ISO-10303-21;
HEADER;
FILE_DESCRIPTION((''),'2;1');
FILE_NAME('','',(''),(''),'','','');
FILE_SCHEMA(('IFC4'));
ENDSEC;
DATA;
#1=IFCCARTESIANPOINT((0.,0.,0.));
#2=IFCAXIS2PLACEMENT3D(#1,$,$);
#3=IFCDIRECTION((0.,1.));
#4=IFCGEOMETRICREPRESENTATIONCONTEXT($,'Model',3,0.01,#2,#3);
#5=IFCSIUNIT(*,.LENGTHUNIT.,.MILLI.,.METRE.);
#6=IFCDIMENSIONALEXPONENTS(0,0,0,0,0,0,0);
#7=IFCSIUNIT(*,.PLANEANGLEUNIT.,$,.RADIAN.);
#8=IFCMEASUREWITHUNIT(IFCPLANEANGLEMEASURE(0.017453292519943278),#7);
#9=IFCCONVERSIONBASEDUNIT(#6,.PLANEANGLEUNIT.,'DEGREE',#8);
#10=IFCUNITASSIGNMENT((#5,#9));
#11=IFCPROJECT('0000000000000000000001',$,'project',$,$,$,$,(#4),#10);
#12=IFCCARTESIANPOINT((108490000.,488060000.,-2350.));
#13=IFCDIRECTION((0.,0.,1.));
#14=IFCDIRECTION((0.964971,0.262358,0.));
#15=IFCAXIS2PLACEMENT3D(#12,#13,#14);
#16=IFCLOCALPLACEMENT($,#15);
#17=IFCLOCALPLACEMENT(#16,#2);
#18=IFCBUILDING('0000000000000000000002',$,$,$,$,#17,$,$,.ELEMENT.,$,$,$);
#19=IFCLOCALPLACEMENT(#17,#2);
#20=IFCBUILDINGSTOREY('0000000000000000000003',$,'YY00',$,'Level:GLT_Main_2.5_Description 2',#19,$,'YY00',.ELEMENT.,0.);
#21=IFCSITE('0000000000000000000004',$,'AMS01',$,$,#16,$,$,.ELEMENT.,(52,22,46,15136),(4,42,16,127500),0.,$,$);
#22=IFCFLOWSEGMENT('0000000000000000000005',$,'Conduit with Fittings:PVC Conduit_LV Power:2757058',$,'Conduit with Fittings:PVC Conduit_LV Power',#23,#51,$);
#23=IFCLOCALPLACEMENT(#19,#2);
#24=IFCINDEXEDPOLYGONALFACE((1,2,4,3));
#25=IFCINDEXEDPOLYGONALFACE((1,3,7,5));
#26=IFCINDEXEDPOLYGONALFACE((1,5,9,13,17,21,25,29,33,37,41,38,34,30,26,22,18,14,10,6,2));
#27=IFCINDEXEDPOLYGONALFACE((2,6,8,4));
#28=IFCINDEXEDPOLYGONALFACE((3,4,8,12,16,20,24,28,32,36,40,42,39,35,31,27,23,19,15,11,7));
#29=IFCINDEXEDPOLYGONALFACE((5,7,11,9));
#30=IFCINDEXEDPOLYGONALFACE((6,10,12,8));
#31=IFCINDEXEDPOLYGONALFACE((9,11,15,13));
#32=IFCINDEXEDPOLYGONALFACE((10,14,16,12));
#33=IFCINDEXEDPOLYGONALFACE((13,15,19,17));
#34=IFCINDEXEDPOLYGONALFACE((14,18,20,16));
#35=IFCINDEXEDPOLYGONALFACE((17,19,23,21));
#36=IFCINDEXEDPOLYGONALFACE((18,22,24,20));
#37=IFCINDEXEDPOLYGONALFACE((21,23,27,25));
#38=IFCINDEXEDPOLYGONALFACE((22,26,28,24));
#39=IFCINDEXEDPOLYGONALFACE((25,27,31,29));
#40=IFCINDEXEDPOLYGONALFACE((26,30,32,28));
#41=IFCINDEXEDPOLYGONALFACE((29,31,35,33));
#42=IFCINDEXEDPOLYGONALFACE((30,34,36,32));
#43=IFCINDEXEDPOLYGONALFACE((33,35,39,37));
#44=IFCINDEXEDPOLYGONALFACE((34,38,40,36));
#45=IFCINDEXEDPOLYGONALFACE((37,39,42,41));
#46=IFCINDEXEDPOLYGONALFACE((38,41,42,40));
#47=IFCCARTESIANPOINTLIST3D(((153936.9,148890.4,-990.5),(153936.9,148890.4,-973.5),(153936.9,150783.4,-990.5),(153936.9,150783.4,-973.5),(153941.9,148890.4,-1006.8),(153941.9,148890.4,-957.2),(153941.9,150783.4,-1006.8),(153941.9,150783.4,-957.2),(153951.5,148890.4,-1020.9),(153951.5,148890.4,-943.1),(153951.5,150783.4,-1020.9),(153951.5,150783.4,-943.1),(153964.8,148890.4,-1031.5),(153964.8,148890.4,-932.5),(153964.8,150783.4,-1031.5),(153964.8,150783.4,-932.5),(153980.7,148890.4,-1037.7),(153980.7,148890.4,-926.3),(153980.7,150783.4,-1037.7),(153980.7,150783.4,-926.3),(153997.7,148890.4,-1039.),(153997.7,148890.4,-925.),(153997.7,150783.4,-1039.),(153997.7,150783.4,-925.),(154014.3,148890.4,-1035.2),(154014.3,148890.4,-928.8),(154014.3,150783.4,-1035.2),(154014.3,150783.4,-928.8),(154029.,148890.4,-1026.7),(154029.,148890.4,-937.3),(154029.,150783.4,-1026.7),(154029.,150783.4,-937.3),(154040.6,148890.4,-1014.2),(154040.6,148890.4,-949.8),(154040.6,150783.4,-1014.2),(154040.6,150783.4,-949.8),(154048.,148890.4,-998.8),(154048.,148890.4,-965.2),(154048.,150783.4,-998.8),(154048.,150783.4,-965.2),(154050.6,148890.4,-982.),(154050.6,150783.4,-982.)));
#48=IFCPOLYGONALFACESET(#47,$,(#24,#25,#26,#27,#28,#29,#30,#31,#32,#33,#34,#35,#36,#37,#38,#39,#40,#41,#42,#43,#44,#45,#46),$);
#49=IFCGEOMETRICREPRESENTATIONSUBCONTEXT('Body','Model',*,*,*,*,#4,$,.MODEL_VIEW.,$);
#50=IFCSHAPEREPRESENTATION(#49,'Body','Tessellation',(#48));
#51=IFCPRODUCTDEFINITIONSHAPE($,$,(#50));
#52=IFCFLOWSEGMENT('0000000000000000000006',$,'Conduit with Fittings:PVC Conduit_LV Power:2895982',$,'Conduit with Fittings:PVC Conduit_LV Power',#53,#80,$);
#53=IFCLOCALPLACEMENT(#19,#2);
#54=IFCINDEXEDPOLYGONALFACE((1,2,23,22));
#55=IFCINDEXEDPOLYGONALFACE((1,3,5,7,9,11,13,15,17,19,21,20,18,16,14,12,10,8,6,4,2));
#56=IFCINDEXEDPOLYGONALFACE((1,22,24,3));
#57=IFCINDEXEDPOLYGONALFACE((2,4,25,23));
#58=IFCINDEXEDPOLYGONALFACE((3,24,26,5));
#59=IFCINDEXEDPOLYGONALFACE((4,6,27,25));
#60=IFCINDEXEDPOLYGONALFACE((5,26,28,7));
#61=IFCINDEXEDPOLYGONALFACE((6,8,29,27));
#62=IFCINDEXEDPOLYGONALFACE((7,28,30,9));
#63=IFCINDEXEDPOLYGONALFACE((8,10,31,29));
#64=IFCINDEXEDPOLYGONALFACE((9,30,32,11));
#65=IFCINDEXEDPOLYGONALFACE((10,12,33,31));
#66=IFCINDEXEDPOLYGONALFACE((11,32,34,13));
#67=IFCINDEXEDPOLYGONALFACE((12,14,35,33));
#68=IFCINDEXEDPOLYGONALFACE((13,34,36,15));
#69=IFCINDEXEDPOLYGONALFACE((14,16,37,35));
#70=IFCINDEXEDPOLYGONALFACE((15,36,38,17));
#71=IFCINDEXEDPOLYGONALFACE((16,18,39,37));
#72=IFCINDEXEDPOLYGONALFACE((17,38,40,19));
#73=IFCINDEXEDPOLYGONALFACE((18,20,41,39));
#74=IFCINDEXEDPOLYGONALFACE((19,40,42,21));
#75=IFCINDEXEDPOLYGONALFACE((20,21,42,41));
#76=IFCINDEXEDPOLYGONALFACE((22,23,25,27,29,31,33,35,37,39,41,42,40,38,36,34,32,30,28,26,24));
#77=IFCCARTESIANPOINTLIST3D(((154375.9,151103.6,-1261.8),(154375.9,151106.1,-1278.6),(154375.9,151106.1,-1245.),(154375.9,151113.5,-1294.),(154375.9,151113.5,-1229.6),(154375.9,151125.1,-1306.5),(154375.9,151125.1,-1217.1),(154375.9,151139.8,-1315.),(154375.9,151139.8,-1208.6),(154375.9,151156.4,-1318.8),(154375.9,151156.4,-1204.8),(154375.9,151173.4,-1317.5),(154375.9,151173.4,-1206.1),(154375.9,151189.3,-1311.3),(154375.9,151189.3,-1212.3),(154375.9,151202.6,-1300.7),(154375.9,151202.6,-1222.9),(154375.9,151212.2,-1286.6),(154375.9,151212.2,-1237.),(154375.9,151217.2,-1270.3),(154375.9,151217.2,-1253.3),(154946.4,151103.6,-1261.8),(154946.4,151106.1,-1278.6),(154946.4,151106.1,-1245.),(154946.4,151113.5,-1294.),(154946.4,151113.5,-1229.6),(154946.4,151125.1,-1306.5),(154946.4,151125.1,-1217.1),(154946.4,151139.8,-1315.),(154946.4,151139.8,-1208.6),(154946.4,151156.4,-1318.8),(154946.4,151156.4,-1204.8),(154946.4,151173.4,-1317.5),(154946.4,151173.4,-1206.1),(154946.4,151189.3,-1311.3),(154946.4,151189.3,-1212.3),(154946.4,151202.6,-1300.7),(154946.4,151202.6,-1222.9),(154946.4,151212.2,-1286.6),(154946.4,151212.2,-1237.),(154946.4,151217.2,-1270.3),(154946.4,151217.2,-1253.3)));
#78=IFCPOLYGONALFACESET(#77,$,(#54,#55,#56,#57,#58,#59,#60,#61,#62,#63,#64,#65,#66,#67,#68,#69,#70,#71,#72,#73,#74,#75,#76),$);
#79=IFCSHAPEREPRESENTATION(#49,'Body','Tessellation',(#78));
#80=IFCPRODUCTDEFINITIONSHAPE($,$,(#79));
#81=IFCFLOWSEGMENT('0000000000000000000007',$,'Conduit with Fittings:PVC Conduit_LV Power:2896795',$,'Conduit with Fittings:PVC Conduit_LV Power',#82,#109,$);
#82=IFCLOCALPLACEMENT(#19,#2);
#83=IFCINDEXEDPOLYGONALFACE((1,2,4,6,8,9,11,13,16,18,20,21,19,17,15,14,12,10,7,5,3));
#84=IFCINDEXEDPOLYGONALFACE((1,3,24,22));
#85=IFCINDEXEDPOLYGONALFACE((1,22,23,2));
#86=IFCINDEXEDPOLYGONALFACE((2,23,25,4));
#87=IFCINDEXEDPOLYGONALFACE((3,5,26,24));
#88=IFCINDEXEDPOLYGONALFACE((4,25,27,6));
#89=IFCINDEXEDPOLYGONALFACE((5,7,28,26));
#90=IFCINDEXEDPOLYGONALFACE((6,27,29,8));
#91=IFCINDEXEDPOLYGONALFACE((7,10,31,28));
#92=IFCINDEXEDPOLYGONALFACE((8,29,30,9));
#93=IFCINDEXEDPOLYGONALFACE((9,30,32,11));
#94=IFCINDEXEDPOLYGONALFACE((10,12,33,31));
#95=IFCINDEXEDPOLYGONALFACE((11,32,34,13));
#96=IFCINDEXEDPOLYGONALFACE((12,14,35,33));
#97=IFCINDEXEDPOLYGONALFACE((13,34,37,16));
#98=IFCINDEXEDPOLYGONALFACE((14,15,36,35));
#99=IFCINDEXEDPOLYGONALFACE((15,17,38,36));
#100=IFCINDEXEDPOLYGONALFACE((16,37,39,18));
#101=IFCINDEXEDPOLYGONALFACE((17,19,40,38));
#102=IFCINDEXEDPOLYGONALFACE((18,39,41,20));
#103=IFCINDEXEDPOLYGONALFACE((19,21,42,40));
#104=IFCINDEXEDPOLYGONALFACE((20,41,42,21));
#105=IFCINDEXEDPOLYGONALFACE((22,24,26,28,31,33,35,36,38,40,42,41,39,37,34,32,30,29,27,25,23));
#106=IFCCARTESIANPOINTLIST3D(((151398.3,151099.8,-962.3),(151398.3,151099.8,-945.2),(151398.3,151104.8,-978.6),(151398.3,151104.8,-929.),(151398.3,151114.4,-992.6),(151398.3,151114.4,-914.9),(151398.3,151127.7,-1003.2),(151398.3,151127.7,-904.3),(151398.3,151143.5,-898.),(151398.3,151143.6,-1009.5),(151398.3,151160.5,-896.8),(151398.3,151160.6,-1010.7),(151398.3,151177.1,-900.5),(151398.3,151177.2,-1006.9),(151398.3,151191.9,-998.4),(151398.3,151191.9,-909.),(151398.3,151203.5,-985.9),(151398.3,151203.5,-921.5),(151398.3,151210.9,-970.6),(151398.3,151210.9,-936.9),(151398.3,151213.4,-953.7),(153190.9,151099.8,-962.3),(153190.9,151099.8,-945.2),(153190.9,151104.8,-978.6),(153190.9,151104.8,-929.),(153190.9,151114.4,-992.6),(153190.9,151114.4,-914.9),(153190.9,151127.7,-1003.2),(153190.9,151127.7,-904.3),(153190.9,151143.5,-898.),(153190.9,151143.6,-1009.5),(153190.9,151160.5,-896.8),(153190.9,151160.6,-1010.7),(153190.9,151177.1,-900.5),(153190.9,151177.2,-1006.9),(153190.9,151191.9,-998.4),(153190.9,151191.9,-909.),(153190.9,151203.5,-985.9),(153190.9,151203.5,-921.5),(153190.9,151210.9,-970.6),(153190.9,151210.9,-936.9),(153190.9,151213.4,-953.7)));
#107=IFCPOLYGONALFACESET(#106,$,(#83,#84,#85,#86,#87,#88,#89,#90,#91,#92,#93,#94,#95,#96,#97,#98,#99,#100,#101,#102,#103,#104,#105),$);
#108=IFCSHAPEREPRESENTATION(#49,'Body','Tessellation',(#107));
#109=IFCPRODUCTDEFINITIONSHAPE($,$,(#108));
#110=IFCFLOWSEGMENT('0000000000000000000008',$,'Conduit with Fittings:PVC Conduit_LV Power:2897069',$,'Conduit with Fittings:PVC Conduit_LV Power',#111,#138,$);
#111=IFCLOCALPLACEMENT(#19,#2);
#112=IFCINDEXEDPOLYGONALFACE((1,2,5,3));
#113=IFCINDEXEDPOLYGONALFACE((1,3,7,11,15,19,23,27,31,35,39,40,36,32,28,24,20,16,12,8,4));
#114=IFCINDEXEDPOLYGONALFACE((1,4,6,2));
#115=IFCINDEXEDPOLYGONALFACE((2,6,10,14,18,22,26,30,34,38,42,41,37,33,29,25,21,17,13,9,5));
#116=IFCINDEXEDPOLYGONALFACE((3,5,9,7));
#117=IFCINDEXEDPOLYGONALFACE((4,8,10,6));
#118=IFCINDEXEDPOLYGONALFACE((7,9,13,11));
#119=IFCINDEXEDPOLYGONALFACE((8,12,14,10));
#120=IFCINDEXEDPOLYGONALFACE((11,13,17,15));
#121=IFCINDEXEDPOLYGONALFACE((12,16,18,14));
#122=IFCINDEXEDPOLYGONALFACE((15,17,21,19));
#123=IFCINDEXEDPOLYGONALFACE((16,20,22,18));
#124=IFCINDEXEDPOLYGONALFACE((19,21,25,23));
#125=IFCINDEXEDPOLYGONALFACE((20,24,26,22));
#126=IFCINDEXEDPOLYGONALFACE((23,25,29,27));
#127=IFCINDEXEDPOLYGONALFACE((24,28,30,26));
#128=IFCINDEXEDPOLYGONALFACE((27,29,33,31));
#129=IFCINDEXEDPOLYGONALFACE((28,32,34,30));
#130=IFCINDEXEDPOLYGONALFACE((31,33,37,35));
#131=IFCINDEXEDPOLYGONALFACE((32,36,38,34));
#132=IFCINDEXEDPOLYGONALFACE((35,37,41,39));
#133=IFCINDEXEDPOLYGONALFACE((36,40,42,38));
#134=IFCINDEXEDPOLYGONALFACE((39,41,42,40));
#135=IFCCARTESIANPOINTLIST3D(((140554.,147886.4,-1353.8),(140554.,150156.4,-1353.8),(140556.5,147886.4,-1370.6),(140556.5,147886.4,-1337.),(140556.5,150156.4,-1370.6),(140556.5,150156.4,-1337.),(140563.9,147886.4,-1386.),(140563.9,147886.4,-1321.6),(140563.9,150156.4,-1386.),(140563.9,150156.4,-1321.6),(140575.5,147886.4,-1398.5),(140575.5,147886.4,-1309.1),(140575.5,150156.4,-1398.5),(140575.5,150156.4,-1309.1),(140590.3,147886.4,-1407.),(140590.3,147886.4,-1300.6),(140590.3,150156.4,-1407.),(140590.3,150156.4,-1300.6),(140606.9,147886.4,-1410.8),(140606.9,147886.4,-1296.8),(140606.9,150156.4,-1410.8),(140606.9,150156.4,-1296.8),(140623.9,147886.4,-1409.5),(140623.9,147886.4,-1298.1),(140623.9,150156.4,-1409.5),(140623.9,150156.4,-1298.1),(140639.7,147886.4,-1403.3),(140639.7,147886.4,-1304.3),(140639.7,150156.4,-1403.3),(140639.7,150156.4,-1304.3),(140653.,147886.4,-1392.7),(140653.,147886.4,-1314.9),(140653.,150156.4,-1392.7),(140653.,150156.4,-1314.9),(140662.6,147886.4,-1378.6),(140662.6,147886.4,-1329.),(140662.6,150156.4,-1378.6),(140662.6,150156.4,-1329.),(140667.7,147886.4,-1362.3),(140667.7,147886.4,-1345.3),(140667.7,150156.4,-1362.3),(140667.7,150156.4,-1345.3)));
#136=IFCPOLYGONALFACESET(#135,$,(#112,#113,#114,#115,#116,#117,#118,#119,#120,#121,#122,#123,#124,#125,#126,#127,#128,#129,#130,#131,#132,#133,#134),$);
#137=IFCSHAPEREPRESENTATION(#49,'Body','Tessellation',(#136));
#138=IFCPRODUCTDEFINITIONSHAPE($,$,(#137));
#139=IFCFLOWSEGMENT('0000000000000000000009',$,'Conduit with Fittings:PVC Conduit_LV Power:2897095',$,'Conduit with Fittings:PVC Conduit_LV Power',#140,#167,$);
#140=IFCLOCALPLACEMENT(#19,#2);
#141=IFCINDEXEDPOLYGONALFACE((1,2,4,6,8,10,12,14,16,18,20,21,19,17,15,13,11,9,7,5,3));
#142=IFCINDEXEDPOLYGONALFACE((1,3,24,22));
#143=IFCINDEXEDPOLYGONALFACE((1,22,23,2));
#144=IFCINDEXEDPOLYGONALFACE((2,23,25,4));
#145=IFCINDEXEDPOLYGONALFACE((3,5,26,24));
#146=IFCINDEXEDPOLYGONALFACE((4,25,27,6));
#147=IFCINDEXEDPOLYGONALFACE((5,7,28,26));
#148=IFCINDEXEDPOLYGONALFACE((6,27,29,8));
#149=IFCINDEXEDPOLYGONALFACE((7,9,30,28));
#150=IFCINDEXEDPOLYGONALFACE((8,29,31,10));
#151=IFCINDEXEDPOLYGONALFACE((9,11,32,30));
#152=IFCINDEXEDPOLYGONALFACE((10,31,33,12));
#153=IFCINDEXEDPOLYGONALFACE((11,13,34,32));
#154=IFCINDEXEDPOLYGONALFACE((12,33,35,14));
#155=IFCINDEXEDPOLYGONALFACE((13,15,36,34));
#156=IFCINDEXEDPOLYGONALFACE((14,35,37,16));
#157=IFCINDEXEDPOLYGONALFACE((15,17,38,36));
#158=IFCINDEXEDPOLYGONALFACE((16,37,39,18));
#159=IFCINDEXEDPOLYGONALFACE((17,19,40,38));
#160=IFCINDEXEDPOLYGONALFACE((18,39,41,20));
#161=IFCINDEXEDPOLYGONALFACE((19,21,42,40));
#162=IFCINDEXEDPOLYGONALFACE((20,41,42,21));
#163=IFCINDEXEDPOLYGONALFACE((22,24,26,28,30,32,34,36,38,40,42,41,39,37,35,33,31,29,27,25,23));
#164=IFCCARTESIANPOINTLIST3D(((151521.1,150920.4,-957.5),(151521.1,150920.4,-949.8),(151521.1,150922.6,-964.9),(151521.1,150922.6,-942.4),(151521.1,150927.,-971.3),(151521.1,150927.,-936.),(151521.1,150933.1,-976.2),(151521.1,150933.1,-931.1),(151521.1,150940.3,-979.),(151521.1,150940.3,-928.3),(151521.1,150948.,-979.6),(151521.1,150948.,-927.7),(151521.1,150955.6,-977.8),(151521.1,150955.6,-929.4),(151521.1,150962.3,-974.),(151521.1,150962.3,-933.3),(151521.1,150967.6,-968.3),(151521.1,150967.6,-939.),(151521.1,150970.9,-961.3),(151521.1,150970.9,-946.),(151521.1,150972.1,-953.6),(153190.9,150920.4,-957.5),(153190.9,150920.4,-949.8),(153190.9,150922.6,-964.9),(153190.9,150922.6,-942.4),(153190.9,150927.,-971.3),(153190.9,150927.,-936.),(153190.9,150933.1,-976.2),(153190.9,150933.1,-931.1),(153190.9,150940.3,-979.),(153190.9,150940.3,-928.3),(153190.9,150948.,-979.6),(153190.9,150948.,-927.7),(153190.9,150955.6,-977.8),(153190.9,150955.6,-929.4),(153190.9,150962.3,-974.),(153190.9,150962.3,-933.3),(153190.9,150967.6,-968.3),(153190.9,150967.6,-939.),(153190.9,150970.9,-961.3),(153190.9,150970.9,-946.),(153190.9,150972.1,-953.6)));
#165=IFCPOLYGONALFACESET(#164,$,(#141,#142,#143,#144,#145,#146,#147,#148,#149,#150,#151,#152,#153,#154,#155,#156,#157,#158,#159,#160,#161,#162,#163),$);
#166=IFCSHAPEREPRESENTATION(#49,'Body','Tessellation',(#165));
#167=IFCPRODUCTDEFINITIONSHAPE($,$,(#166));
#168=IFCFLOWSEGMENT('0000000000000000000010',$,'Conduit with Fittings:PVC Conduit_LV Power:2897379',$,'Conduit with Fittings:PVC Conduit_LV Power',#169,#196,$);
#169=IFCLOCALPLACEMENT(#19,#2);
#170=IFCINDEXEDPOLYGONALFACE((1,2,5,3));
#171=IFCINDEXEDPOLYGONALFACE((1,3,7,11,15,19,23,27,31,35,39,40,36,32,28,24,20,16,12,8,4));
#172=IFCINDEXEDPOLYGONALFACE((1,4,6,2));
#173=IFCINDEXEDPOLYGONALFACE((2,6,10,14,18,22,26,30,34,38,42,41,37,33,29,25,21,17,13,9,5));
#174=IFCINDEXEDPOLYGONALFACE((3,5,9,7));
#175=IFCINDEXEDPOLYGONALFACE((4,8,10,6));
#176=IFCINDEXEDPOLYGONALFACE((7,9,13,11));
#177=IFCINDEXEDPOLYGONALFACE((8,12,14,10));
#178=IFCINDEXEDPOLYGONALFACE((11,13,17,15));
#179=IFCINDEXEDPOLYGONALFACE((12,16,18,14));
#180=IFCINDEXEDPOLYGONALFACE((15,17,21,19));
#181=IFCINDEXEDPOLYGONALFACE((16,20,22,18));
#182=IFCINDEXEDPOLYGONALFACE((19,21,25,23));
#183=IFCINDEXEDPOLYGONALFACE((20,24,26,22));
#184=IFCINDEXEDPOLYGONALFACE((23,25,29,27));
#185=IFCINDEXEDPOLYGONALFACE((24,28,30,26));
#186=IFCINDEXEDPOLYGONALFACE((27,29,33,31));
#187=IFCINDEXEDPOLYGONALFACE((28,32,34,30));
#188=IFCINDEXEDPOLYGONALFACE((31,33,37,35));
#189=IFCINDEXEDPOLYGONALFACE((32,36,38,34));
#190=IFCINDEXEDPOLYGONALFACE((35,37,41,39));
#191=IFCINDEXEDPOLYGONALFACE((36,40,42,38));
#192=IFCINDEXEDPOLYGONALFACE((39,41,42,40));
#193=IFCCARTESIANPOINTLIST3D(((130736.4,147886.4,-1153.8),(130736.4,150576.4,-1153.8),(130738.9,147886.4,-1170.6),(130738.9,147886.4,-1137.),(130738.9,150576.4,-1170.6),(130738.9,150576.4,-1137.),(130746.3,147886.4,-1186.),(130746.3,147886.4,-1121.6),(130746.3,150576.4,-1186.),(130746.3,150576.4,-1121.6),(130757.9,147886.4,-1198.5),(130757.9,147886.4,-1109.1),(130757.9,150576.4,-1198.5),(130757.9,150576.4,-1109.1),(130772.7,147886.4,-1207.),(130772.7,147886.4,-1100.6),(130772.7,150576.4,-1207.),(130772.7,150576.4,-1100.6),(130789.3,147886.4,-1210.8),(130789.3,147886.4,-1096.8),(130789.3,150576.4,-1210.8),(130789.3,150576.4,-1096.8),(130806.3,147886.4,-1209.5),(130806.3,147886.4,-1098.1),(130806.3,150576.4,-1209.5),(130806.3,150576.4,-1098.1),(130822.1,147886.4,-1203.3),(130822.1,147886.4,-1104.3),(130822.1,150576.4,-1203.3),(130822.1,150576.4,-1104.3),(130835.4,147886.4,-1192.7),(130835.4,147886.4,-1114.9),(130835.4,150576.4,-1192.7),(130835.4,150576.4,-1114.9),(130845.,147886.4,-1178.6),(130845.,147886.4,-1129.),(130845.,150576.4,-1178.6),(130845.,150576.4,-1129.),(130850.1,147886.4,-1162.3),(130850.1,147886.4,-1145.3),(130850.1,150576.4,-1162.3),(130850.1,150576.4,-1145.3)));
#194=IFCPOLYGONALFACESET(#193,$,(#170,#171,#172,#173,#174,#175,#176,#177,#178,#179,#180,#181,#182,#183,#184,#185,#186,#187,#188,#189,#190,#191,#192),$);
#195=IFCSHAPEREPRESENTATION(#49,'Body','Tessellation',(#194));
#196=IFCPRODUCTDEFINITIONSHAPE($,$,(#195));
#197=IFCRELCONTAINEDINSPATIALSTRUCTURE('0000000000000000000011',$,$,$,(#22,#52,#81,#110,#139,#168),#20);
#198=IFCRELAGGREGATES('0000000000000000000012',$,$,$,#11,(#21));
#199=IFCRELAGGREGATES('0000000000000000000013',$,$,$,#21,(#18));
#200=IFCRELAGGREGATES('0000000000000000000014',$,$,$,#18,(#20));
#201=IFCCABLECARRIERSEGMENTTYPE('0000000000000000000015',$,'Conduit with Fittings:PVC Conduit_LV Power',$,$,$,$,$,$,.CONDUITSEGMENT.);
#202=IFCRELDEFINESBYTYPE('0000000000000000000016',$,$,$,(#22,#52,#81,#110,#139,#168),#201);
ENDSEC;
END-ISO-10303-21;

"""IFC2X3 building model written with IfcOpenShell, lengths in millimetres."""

from ifc_helpers import new_model, entity, si_unit, converted_unit, direction, frame, frame_2d, origin, origin_2d_with_axis, place, context, subcontext, project, spatial, circle, extrude, type_object, element, save


model = new_model("IFC2X3")

# Units and contexts
model_context = context("Model", 3, precision=0.01, world=origin(), true_north=direction((0.0, 1.0)))
body_context = subcontext(model_context, "Body", "Model", "MODEL_VIEW")
ifc_project = project(units=[si_unit("LENGTHUNIT", "METRE", prefix="MILLI"), converted_unit("PLANEANGLEUNIT", "DEGREE", entity("IfcPlaneAngleMeasure", 0.017453292519943278), si_unit("PLANEANGLEUNIT", "RADIAN"), dimensions=[0, 0, 0, 0, 0, 0, 0])], contexts=[model_context])

# Site, building, storey
site_placement = place(None, frame((108490000.0, 488060000.0, -2350.0), z_axis=(0.0, 0.0, 1.0), x_axis=(0.964971, 0.262358, 0.0)))
site = spatial("IfcSite", under=ifc_project, at=site_placement, Name="AMS01", CompositionType="ELEMENT", RefLatitude=(52, 22, 46, 15136), RefLongitude=(4, 42, 16, 127500), RefElevation=0.0)
building_placement = place(site_placement, origin())
building = spatial("IfcBuilding", under=site, at=building_placement, CompositionType="ELEMENT")
storey_placement = place(building_placement, origin())
storey = spatial("IfcBuildingStorey", under=building, at=storey_placement, Name="YY00", ObjectType="Level:GLT_Main_2.5_Description 2", LongName="YY00", CompositionType="ELEMENT", Elevation=0.0)

# Flow segments
cable_carrier_segment_type = type_object("IfcCableCarrierSegmentType", Name="Conduit with Fittings:PVC Conduit_LV Power", PredefinedType="CONDUITSEGMENT")
flow_segment_1_placement = place(storey_placement, origin())
element("IfcFlowSegment", 1, at=flow_segment_1_placement, inside=storey, type_object=cable_carrier_segment_type, Name="Conduit with Fittings:PVC Conduit_LV Power:2757058", ObjectType="Conduit with Fittings:PVC Conduit_LV Power", context=body_context, shape_type="SweptSolid", body=[
    extrude(circle(Radius=57.2, at=origin_2d_with_axis()), frame((153993.4, 148890.4, -982.0), z_axis=(0.0, 1.0, 0.0), x_axis=(1.0, 0.0, 0.0)), (0.0, 0.0, 1.0), 1892.9),
])
flow_segment_2_placement = place(storey_placement, origin())
element("IfcFlowSegment", 2, at=flow_segment_2_placement, inside=storey, type_object=cable_carrier_segment_type, Name="Conduit with Fittings:PVC Conduit_LV Power:2895982", ObjectType="Conduit with Fittings:PVC Conduit_LV Power", context=body_context, shape_type="SweptSolid", body=[
    extrude(circle(Radius=57.2, at=origin_2d_with_axis()), frame((154375.9, 151160.7, -1261.8), z_axis=(1.0, 0.0, 0.0), x_axis=(0.0, -1.0, 0.0)), (0.0, 0.0, 1.0), 570.5),
])
flow_segment_3_placement = place(storey_placement, origin())
element("IfcFlowSegment", 3, at=flow_segment_3_placement, inside=storey, type_object=cable_carrier_segment_type, Name="Conduit with Fittings:PVC Conduit_LV Power:2896795", ObjectType="Conduit with Fittings:PVC Conduit_LV Power", context=body_context, shape_type="SweptSolid", body=[
    extrude(circle(Radius=57.2, at=frame_2d((0.0, 0.0), x_axis=(1.0, 0.0))), frame((151398.3, 151156.3, -953.7), z_axis=(1.0, 0.0, 0.0), x_axis=(0.0, 1.0, 0.00034)), (0.0, 0.0, 1.0), 1792.6),
])
flow_segment_4_placement = place(storey_placement, origin())
element("IfcFlowSegment", 4, at=flow_segment_4_placement, inside=storey, type_object=cable_carrier_segment_type, Name="Conduit with Fittings:PVC Conduit_LV Power:2897069", ObjectType="Conduit with Fittings:PVC Conduit_LV Power", context=body_context, shape_type="SweptSolid", body=[
    extrude(circle(Radius=57.2, at=origin_2d_with_axis()), frame((140611.1, 147886.4, -1353.8), z_axis=(0.0, 1.0, 0.0), x_axis=(-1.0, 0.0, 0.0)), (0.0, 0.0, 1.0), 2270.0),
])
flow_segment_5_placement = place(storey_placement, origin())
element("IfcFlowSegment", 5, at=flow_segment_5_placement, inside=storey, type_object=cable_carrier_segment_type, Name="Conduit with Fittings:PVC Conduit_LV Power:2897095", ObjectType="Conduit with Fittings:PVC Conduit_LV Power", context=body_context, shape_type="SweptSolid", body=[
    extrude(circle(Radius=26.0, at=origin_2d_with_axis()), frame((151521.1, 150946.1, -953.6), z_axis=(1.0, 0.0, 0.0), x_axis=(0.0, 1.0, 0.0)), (0.0, 0.0, 1.0), 1669.8),
])
flow_segment_6_placement = place(storey_placement, origin())
element("IfcFlowSegment", 6, at=flow_segment_6_placement, inside=storey, type_object=cable_carrier_segment_type, Name="Conduit with Fittings:PVC Conduit_LV Power:2897379", ObjectType="Conduit with Fittings:PVC Conduit_LV Power", context=body_context, shape_type="SweptSolid", body=[
    extrude(circle(Radius=57.2, at=frame_2d((0.0, 0.0), x_axis=(1.0, 0.0))), frame((130793.5, 147886.4, -1153.8), z_axis=(0.0, 1.0, 0.0), x_axis=(-1.0, 0.0, 0.0)), (0.0, 0.0, 1.0), 2690.0),
])

save(model, "model.ifc")
